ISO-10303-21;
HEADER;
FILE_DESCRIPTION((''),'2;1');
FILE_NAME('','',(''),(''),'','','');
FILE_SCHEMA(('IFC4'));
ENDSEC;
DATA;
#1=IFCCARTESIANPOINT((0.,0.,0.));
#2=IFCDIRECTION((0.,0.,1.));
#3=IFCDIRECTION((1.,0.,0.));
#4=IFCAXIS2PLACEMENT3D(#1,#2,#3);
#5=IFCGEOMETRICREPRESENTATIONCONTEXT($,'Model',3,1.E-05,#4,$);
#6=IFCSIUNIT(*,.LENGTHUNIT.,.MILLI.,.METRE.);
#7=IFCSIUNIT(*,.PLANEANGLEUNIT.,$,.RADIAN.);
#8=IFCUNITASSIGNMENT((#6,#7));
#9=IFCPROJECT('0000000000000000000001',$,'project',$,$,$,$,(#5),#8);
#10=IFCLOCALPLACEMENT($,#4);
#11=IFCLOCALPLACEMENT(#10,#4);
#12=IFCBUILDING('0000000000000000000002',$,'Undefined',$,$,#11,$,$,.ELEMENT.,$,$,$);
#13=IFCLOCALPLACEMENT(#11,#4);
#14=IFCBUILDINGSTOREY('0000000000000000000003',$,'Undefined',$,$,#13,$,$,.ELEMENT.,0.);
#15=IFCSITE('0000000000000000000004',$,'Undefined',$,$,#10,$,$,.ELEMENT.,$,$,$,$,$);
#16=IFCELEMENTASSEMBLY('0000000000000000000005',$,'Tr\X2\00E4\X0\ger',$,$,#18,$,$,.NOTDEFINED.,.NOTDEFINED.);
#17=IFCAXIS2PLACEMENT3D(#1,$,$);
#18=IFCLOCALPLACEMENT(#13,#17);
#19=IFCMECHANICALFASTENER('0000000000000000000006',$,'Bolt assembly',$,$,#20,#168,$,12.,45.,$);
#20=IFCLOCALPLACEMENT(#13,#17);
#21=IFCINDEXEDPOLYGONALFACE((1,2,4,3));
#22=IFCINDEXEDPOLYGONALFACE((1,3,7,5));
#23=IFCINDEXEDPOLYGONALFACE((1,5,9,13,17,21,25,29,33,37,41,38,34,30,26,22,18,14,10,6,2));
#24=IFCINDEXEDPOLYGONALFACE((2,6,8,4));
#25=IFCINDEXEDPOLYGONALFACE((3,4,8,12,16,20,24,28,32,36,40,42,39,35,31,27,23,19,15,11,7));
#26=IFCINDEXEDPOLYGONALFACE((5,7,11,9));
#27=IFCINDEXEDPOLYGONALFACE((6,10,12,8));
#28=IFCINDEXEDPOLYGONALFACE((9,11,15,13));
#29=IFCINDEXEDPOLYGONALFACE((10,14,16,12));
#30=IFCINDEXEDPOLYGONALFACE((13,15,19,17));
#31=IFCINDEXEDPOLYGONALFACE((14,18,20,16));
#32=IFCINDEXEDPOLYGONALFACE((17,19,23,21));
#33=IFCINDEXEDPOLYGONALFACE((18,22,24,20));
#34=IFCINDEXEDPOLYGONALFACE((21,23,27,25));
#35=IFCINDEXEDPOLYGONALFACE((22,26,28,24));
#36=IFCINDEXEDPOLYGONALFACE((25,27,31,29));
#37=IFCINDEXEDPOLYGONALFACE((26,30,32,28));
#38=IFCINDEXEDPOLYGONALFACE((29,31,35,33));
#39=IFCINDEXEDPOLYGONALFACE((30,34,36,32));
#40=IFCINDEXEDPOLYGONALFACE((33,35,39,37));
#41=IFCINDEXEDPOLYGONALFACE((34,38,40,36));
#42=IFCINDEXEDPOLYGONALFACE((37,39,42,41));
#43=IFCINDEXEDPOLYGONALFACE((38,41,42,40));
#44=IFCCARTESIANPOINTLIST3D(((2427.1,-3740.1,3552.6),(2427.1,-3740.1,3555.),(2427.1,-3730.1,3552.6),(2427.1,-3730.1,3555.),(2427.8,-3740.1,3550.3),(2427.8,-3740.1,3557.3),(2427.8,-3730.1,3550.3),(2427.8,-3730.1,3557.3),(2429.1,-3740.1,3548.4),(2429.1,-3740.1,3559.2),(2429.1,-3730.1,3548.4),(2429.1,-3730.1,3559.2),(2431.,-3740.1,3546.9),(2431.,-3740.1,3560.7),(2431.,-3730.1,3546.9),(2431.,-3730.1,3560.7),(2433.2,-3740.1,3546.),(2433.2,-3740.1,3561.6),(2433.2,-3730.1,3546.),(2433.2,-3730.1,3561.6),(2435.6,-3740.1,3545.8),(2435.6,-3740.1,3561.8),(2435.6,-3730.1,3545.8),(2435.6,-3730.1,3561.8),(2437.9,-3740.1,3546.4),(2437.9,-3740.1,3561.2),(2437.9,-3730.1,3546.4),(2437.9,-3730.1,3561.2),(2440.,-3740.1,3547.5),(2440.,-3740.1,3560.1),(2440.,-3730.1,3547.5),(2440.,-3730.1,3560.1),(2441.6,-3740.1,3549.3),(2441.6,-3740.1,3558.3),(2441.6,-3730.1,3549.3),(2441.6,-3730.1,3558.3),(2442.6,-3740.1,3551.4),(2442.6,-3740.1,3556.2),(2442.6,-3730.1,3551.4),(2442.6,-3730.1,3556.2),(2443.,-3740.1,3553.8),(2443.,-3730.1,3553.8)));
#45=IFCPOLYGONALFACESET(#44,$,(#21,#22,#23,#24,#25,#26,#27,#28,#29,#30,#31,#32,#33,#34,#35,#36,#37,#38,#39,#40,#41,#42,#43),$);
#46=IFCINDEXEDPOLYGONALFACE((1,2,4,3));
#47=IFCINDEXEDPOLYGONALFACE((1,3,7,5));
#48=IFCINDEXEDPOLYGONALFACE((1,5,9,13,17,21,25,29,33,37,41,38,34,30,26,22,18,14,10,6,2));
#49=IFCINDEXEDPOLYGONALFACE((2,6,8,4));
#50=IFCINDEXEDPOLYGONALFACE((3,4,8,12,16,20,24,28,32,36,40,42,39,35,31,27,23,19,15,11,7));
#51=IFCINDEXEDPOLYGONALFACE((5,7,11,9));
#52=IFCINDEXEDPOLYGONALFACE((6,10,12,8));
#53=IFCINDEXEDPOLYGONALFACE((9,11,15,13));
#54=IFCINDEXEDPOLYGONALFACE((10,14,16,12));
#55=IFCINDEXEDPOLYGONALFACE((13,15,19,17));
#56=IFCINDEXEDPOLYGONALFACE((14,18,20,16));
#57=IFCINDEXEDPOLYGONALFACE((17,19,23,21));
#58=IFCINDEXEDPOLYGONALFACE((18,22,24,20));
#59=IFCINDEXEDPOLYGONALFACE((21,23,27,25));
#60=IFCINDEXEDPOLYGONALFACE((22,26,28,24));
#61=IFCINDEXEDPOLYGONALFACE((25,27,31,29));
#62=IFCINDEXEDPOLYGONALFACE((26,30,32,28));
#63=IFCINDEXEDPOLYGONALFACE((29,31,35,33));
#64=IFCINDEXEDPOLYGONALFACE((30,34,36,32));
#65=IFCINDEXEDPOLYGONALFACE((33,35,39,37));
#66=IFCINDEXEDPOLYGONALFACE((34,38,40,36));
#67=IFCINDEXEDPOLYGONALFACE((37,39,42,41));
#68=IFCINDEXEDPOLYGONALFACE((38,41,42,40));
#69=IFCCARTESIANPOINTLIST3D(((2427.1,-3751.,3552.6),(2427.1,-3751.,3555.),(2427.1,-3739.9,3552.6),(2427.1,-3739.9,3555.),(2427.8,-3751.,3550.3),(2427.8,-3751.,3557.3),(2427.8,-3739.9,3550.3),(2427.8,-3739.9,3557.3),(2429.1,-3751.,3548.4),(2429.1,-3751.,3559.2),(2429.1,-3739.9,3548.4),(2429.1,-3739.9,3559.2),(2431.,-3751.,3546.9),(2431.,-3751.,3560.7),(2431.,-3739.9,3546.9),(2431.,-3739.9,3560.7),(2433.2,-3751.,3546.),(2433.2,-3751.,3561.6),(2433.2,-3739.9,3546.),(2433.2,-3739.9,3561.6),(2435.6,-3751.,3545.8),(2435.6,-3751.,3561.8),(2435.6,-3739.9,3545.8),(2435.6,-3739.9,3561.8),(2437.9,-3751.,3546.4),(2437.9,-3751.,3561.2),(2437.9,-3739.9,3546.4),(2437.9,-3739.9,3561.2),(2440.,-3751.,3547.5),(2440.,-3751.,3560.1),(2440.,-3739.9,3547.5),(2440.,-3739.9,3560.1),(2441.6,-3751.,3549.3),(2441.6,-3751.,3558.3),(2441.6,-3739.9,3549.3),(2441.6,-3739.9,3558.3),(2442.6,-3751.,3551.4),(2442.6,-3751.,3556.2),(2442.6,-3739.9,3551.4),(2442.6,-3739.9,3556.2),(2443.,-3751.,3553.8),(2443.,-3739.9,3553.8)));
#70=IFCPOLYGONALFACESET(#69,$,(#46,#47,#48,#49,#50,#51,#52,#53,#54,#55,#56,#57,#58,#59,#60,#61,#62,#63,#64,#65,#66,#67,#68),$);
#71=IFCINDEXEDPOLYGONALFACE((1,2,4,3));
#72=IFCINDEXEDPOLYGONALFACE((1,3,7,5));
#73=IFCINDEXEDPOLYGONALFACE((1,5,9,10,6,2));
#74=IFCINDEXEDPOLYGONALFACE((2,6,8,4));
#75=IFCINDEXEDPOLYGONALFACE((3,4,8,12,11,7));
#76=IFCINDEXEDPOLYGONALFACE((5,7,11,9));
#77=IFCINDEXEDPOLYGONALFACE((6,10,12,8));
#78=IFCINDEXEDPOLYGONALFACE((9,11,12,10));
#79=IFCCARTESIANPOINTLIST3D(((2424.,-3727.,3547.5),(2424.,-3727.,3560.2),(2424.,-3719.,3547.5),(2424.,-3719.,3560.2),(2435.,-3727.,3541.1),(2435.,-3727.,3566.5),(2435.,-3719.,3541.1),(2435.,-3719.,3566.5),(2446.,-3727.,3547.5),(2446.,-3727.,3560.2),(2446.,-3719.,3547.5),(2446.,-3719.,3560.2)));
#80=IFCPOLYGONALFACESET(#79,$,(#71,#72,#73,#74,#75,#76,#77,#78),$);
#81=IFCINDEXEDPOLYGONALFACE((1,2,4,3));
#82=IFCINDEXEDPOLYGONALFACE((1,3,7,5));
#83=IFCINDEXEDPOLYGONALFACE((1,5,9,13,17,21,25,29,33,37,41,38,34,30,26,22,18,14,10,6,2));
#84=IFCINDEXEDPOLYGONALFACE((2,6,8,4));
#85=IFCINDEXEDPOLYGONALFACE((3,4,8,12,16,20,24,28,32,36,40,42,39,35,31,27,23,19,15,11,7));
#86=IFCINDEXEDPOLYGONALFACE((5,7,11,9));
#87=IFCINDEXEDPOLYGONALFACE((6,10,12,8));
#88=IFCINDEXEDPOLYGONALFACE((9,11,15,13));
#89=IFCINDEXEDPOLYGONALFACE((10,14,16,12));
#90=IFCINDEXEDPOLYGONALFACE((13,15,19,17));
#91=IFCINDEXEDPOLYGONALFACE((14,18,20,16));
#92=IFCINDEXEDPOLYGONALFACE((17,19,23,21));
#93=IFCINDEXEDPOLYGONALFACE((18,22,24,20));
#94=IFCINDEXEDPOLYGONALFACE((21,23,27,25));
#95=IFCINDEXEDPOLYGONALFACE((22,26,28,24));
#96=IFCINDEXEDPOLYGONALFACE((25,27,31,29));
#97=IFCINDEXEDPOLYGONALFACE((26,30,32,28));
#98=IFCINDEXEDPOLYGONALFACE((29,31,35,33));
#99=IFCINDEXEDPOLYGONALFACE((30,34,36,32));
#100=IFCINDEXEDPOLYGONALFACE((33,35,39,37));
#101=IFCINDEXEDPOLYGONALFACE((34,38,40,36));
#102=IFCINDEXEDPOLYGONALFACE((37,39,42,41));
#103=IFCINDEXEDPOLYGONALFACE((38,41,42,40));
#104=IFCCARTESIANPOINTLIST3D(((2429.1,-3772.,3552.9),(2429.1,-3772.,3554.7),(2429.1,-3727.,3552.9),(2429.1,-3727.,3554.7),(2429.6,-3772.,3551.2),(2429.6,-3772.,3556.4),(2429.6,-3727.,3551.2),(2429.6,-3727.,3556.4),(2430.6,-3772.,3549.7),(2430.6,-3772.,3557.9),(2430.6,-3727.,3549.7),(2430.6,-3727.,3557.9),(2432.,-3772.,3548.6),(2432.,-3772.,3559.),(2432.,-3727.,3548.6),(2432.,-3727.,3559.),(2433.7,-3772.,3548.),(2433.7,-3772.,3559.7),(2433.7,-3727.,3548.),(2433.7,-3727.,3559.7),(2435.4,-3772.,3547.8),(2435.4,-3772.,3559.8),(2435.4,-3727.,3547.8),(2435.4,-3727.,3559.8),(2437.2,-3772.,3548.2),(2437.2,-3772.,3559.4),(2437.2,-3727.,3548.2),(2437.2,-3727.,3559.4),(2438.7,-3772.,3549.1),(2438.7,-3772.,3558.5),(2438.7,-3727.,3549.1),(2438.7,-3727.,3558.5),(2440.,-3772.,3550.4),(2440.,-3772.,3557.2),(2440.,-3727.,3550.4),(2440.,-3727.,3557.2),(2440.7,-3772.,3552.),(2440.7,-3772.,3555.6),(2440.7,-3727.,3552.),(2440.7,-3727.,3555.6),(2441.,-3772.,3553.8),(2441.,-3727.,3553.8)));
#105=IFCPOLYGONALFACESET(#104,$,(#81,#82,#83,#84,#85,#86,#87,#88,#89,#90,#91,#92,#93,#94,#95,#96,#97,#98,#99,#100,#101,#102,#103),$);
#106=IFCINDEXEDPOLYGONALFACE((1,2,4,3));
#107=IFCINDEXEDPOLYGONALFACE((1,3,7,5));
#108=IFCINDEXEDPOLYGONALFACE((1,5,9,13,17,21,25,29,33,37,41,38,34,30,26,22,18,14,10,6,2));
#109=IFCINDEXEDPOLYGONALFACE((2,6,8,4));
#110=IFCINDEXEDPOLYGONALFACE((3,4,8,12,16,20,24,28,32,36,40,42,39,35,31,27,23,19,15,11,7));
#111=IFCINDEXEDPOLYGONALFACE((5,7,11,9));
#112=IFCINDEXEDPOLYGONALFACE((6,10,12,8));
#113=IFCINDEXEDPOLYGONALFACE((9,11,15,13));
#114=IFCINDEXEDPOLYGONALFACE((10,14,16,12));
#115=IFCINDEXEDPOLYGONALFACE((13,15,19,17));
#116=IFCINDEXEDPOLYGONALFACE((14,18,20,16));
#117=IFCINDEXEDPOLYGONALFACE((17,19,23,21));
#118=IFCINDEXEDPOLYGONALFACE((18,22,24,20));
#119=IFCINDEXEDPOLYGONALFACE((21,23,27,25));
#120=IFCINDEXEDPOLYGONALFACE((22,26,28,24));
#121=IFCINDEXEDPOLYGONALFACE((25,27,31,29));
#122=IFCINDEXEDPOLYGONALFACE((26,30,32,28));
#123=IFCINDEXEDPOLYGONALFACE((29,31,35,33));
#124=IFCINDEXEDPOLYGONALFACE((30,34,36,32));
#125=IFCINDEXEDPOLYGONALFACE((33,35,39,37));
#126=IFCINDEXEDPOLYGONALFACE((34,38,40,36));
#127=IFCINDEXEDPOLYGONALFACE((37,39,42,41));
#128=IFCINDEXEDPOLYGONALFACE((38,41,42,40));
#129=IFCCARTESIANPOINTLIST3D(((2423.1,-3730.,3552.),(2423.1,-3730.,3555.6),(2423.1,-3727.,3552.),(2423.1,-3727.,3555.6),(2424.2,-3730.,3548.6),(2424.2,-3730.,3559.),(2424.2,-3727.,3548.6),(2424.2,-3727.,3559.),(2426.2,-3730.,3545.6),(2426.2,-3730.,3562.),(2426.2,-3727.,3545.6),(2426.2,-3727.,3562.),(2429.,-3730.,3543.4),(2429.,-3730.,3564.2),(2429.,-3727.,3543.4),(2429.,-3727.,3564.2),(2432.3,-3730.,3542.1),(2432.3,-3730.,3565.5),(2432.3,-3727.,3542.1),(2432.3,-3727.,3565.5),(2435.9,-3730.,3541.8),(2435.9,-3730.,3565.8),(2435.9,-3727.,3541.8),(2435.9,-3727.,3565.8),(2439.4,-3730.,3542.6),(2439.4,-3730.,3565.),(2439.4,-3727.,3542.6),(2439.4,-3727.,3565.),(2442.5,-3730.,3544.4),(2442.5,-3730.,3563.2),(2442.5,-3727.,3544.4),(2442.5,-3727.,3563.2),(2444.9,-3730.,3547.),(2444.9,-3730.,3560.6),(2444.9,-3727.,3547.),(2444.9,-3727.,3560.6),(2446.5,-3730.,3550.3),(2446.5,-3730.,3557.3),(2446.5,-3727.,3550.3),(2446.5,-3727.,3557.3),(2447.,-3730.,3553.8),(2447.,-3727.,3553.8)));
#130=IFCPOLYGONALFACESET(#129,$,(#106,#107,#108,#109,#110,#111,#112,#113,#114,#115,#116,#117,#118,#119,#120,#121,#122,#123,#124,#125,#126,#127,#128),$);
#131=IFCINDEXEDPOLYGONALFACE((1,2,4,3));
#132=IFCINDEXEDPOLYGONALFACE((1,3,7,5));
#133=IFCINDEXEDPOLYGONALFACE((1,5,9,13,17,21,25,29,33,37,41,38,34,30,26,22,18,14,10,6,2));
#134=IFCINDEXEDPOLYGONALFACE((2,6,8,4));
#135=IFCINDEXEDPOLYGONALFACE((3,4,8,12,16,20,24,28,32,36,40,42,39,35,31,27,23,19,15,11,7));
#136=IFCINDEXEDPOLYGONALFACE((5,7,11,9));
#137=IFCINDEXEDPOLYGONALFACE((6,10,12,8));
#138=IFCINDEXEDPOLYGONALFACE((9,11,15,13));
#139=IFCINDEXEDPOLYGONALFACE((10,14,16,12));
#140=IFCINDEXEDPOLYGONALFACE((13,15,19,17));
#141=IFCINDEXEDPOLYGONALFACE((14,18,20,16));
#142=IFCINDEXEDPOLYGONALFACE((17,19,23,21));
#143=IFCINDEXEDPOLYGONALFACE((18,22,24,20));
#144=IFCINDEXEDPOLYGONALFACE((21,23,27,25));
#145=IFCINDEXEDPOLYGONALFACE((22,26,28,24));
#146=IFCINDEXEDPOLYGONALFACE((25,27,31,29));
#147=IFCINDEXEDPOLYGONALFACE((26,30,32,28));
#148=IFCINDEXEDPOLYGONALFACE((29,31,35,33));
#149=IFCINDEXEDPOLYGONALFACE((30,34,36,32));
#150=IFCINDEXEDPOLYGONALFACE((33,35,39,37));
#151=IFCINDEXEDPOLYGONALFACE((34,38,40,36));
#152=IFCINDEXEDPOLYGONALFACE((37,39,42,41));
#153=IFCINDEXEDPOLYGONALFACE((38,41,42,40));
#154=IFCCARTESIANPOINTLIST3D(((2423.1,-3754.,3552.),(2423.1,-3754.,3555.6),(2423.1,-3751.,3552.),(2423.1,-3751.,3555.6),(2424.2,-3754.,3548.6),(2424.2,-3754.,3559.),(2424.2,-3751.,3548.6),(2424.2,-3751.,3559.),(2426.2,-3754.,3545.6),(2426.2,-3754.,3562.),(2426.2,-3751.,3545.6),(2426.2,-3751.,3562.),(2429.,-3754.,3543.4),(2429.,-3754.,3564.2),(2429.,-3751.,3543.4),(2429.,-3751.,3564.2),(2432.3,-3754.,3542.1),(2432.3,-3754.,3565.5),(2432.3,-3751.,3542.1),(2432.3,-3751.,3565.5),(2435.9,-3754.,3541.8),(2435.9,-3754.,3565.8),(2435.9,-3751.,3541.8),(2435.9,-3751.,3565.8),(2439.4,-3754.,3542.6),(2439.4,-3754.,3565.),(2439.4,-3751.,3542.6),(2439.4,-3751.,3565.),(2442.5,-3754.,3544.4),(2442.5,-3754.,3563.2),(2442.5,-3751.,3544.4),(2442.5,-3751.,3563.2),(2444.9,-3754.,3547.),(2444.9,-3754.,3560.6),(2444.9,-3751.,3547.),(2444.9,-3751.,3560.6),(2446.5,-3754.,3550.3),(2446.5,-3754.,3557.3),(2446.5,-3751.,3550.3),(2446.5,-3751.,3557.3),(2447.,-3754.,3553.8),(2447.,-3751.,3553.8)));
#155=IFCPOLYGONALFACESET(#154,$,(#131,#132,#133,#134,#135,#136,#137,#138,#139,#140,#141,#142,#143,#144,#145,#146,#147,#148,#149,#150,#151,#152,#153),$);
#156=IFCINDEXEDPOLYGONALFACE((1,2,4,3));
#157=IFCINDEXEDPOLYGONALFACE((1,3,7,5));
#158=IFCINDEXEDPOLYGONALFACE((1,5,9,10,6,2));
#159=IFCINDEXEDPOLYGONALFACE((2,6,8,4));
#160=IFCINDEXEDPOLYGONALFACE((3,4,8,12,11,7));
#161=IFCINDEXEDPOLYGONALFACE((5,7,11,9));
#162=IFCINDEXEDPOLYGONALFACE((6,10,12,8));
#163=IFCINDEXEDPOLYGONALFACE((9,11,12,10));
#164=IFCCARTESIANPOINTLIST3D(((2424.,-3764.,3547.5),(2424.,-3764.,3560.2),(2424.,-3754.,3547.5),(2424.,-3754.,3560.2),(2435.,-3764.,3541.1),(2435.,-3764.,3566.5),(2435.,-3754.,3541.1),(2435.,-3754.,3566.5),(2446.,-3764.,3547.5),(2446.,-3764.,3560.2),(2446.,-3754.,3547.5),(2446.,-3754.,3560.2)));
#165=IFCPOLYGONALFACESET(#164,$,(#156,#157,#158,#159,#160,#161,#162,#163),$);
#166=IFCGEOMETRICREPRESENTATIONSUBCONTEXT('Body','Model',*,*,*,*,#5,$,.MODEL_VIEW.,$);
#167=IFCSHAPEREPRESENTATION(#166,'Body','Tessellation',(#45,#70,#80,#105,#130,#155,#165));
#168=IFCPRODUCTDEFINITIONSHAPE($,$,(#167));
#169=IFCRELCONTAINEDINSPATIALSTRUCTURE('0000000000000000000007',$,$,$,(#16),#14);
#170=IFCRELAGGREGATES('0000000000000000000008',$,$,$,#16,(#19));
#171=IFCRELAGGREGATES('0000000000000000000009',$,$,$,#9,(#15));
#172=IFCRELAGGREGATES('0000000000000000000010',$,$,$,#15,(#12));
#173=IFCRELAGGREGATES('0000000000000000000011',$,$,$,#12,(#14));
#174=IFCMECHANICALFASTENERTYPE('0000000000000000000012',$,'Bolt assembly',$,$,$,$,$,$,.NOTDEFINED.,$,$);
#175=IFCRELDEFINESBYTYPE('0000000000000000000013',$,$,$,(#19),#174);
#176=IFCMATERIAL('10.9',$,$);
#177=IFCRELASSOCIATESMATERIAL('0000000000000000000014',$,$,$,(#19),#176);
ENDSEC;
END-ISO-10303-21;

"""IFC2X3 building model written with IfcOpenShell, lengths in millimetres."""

from ifc_helpers import new_model, si_unit, frame, origin_with_axes, origin_2d_with_axis, place, context, subcontext, project, spatial, polyline, circle, outline, extrude, source, transform, mapped, material, type_object, element, aggregate, save


model = new_model("IFC2X3")

# Units and contexts
model_context = context("Model", 3, precision=1e-05, world=origin_with_axes())
body_context = subcontext(model_context, "Body", "Model", "MODEL_VIEW")
ifc_project = project(units=[si_unit("LENGTHUNIT", "METRE", prefix="MILLI"), si_unit("PLANEANGLEUNIT", "RADIAN")], contexts=[model_context])

# Site, building, storey
site_placement = place(None, origin_with_axes())
site = spatial("IfcSite", under=ifc_project, at=site_placement, Name="Undefined", CompositionType="ELEMENT")
building_placement = place(site_placement, origin_with_axes())
building = spatial("IfcBuilding", under=site, at=building_placement, Name="Undefined", CompositionType="ELEMENT")
storey_placement = place(building_placement, origin_with_axes())
storey = spatial("IfcBuildingStorey", under=building, at=storey_placement, Name="Undefined", CompositionType="ELEMENT", Elevation=0.0)

# Element assembly
assembly_1_placement = place(storey_placement, origin_with_axes())
assembly_1 = element("IfcElementAssembly", 1, at=assembly_1_placement, inside=storey, Name="Träger", AssemblyPlace="NOTDEFINED", PredefinedType="NOTDEFINED")

# Mechanical fastener
ifc_material_1 = material(Name="10.9")
mechanical_fastener_type = type_object("IfcMechanicalFastenerType", Name="Bolt assembly")
shared_shape = source(origin_with_axes(), body_context, "Body", "SweptSolid", [
    extrude(circle(Radius=8.0, at=origin_2d_with_axis()), frame((0.0, 0.1, 0.0), z_axis=(0.0, 1.0, 0.0), x_axis=(1.0, 0.0, 0.0)), (0.0, 0.0, 1.0), 10.0),
    extrude(circle(Radius=8.0, at=origin_2d_with_axis()), frame((0.0, 9.9, 0.0), z_axis=(0.0, 1.0, 0.0), x_axis=(1.0, 0.0, 0.0)), (0.0, 0.0, 1.0), 11.1),
    extrude(outline(polyline([(11.0, -6.4), (11.0, 6.4), (0.0, 12.7), (-11.0, 6.4), (-11.0, -6.4), (0.0, -12.7), (11.0, -6.4)])), frame((0.0, -11.0, 0.0), z_axis=(0.0, 1.0, 0.0), x_axis=(1.0, 0.0, 0.0)), (0.0, 0.0, 1.0), 8.0),
    extrude(circle(Radius=6.0, at=origin_2d_with_axis()), frame((0.0, -3.0, 0.0), z_axis=(0.0, 1.0, 0.0), x_axis=(1.0, 0.0, 0.0)), (0.0, 0.0, 1.0), 45.0),
    extrude(circle(Radius=12.0, at=origin_2d_with_axis()), frame((0.0, -3.0, 0.0), z_axis=(0.0, 1.0, 0.0), x_axis=(1.0, 0.0, 0.0)), (0.0, 0.0, 1.0), 3.0),
    extrude(circle(Radius=12.0, at=origin_2d_with_axis()), frame((0.0, 21.0, 0.0), z_axis=(0.0, 1.0, 0.0), x_axis=(1.0, 0.0, 0.0)), (0.0, 0.0, 1.0), 3.0),
    extrude(outline(polyline([(11.0, -6.4), (11.0, 6.4), (0.0, 12.7), (-11.0, 6.4), (-11.0, -6.4), (0.0, -12.7), (11.0, -6.4)])), frame((0.0, 24.0, 0.0), z_axis=(0.0, 1.0, 0.0), x_axis=(1.0, 0.0, 0.0)), (0.0, 0.0, 1.0), 10.0),
])
mechanical_fastener_1_placement = place(assembly_1_placement, frame((2435.0, -3730.0, 3553.8), z_axis=(0.0, 0.0, -1.0), x_axis=(1.0, 0.0, 0.0)))
mechanical_fastener_1 = element("IfcMechanicalFastener", 2, at=mechanical_fastener_1_placement, type_object=mechanical_fastener_type, material=ifc_material_1, Name="Bolt assembly", NominalDiameter=12.0, NominalLength=45.0, context=body_context, shape_type="MappedRepresentation", body=[
    mapped(shared_shape, transform((0.0, 0.0, 0.0))),
])
aggregate(assembly_1, [mechanical_fastener_1])

save(model, "model.ifc")
